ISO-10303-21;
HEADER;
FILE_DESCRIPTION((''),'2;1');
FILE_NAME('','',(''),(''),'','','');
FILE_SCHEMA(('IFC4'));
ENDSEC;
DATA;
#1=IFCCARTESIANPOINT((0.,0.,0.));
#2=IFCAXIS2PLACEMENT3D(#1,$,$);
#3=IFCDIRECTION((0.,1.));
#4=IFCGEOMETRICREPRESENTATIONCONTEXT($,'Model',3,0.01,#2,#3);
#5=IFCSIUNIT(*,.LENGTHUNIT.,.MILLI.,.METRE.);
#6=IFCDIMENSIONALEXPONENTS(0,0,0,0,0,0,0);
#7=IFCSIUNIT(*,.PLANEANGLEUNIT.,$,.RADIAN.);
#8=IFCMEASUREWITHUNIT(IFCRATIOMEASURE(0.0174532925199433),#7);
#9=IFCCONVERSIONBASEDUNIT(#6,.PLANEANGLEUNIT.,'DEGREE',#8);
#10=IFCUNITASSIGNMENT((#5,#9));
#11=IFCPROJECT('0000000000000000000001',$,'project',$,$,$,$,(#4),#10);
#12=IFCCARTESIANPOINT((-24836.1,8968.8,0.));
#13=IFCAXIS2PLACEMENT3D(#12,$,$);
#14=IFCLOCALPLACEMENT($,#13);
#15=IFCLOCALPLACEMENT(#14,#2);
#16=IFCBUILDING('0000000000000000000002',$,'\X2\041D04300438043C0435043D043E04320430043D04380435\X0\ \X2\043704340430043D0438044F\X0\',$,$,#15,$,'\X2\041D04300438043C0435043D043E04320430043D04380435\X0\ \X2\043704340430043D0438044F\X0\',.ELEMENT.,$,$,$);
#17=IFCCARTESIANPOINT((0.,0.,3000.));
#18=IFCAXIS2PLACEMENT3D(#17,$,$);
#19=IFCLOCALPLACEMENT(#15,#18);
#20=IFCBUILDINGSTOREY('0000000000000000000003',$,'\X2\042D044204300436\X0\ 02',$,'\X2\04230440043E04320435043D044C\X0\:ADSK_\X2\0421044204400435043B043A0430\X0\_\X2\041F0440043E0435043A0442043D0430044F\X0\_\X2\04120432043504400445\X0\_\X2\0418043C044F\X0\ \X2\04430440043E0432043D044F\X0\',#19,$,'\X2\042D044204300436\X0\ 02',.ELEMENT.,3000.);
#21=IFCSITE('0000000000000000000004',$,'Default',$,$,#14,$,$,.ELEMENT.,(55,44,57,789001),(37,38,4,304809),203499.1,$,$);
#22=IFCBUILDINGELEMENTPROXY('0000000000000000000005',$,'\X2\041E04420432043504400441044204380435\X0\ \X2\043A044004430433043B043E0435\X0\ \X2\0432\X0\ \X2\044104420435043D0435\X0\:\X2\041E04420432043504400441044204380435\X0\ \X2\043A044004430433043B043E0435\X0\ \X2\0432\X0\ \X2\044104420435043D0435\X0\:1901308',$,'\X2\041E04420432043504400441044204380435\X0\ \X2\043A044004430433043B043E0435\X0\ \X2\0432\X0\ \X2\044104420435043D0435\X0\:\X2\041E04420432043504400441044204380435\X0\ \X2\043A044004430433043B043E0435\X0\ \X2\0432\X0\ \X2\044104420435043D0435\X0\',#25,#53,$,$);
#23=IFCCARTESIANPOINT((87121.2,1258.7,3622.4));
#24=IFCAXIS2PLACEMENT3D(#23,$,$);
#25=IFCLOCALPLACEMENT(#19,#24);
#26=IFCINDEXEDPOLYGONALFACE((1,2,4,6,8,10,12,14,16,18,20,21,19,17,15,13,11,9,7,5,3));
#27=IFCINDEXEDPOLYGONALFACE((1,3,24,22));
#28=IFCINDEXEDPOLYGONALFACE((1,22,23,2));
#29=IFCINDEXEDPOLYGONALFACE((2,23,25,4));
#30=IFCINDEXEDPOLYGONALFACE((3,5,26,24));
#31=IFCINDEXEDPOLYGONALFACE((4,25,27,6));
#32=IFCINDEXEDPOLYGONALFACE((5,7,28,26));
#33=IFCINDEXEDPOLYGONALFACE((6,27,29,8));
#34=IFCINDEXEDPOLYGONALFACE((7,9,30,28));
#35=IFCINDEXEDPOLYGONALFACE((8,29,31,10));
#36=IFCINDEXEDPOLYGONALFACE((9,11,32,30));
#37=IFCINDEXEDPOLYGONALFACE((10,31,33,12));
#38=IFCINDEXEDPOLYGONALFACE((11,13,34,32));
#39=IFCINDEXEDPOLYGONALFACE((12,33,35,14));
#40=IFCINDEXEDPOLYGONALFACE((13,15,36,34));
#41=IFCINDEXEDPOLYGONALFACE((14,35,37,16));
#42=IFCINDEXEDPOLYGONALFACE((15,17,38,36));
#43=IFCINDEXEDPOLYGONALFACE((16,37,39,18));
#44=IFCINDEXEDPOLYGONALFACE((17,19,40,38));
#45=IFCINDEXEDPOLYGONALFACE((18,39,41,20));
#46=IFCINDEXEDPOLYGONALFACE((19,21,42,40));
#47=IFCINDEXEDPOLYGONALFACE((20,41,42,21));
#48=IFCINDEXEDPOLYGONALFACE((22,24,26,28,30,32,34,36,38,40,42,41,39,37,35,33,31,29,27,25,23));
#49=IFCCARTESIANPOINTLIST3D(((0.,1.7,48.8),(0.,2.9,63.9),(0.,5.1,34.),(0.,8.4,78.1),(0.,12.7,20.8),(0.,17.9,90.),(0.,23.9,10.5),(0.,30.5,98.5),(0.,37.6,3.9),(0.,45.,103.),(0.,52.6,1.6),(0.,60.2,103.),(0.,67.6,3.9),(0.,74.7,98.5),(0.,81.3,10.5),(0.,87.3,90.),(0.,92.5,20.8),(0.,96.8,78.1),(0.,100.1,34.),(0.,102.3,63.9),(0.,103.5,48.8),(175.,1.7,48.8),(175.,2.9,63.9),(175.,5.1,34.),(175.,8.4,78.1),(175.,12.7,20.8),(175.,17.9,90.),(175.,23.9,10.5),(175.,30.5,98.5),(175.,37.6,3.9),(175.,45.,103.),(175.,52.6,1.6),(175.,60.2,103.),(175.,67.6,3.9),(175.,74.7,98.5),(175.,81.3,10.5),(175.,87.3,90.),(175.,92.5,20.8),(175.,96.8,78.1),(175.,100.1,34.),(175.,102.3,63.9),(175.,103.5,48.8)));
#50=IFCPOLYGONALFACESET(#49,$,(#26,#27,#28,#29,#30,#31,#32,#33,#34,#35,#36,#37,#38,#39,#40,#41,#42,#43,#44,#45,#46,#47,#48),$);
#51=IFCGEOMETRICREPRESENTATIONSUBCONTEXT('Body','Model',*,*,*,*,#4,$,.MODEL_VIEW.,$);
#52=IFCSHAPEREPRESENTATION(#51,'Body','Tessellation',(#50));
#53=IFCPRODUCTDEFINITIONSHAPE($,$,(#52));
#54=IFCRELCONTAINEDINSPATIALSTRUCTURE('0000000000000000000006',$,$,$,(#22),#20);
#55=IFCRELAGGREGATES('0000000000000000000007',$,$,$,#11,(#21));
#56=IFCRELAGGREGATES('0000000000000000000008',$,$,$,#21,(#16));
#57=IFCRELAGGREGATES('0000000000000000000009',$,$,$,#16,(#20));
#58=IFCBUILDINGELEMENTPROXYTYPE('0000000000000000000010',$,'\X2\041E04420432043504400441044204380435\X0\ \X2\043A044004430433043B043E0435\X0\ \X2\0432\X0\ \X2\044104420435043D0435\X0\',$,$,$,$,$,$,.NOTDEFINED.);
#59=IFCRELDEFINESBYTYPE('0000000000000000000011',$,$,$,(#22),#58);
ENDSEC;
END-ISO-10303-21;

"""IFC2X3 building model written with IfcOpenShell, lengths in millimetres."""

from ifc_helpers import new_model, entity, si_unit, converted_unit, direction, frame, origin, origin_2d_with_axis, place, context, subcontext, project, spatial, circle, extrude, type_object, element, save


model = new_model("IFC2X3")

# Units and contexts
model_context = context("Model", 3, precision=0.01, world=origin(), true_north=direction((0.0, 1.0)))
body_context = subcontext(model_context, "Body", "Model", "MODEL_VIEW")
ifc_project = project(units=[si_unit("LENGTHUNIT", "METRE", prefix="MILLI"), converted_unit("PLANEANGLEUNIT", "DEGREE", entity("IfcRatioMeasure", 0.0174532925199433), si_unit("PLANEANGLEUNIT", "RADIAN"), dimensions=[0, 0, 0, 0, 0, 0, 0])], contexts=[model_context])

# Site, building, storey
site_placement = place(None, frame((-24836.1, 8968.8, 0.0)))
site = spatial("IfcSite", under=ifc_project, at=site_placement, Name="Default", CompositionType="ELEMENT", RefLatitude=(55, 44, 57, 789001), RefLongitude=(37, 38, 4, 304809), RefElevation=203499.1)
building_placement = place(site_placement, origin())
building = spatial("IfcBuilding", under=site, at=building_placement, Name="Наименование здания", LongName="Наименование здания", CompositionType="ELEMENT")
storey_placement = place(building_placement, frame((0.0, 0.0, 3000.0)))
storey = spatial("IfcBuildingStorey", under=building, at=storey_placement, Name="Этаж 02", ObjectType="Уровень:ADSK_Стрелка_Проектная_Вверх_Имя уровня", LongName="Этаж 02", CompositionType="ELEMENT", Elevation=3000.0)

# Building element proxy
building_element_proxy_type_1 = type_object("IfcBuildingElementProxyType", Name="Отверстие круглое в стене", PredefinedType="NOTDEFINED")
proxy_1_placement = place(storey_placement, frame((87121.2, 1258.7, 3622.4)))
element("IfcBuildingElementProxy", 1, at=proxy_1_placement, inside=storey, type_object=building_element_proxy_type_1, Name="Отверстие круглое в стене:Отверстие круглое в стене:1901308", ObjectType="Отверстие круглое в стене:Отверстие круглое в стене", context=body_context, shape_type="SweptSolid", body=[
    extrude(circle(Radius=51.0, at=origin_2d_with_axis()), frame((0.0, 52.6, 52.6), z_axis=(1.0, 0.0, 0.0), x_axis=(0.0, 0.0, -1.0)), (0.0, 0.0, 1.0), 175.0),
])

save(model, "model.ifc")
